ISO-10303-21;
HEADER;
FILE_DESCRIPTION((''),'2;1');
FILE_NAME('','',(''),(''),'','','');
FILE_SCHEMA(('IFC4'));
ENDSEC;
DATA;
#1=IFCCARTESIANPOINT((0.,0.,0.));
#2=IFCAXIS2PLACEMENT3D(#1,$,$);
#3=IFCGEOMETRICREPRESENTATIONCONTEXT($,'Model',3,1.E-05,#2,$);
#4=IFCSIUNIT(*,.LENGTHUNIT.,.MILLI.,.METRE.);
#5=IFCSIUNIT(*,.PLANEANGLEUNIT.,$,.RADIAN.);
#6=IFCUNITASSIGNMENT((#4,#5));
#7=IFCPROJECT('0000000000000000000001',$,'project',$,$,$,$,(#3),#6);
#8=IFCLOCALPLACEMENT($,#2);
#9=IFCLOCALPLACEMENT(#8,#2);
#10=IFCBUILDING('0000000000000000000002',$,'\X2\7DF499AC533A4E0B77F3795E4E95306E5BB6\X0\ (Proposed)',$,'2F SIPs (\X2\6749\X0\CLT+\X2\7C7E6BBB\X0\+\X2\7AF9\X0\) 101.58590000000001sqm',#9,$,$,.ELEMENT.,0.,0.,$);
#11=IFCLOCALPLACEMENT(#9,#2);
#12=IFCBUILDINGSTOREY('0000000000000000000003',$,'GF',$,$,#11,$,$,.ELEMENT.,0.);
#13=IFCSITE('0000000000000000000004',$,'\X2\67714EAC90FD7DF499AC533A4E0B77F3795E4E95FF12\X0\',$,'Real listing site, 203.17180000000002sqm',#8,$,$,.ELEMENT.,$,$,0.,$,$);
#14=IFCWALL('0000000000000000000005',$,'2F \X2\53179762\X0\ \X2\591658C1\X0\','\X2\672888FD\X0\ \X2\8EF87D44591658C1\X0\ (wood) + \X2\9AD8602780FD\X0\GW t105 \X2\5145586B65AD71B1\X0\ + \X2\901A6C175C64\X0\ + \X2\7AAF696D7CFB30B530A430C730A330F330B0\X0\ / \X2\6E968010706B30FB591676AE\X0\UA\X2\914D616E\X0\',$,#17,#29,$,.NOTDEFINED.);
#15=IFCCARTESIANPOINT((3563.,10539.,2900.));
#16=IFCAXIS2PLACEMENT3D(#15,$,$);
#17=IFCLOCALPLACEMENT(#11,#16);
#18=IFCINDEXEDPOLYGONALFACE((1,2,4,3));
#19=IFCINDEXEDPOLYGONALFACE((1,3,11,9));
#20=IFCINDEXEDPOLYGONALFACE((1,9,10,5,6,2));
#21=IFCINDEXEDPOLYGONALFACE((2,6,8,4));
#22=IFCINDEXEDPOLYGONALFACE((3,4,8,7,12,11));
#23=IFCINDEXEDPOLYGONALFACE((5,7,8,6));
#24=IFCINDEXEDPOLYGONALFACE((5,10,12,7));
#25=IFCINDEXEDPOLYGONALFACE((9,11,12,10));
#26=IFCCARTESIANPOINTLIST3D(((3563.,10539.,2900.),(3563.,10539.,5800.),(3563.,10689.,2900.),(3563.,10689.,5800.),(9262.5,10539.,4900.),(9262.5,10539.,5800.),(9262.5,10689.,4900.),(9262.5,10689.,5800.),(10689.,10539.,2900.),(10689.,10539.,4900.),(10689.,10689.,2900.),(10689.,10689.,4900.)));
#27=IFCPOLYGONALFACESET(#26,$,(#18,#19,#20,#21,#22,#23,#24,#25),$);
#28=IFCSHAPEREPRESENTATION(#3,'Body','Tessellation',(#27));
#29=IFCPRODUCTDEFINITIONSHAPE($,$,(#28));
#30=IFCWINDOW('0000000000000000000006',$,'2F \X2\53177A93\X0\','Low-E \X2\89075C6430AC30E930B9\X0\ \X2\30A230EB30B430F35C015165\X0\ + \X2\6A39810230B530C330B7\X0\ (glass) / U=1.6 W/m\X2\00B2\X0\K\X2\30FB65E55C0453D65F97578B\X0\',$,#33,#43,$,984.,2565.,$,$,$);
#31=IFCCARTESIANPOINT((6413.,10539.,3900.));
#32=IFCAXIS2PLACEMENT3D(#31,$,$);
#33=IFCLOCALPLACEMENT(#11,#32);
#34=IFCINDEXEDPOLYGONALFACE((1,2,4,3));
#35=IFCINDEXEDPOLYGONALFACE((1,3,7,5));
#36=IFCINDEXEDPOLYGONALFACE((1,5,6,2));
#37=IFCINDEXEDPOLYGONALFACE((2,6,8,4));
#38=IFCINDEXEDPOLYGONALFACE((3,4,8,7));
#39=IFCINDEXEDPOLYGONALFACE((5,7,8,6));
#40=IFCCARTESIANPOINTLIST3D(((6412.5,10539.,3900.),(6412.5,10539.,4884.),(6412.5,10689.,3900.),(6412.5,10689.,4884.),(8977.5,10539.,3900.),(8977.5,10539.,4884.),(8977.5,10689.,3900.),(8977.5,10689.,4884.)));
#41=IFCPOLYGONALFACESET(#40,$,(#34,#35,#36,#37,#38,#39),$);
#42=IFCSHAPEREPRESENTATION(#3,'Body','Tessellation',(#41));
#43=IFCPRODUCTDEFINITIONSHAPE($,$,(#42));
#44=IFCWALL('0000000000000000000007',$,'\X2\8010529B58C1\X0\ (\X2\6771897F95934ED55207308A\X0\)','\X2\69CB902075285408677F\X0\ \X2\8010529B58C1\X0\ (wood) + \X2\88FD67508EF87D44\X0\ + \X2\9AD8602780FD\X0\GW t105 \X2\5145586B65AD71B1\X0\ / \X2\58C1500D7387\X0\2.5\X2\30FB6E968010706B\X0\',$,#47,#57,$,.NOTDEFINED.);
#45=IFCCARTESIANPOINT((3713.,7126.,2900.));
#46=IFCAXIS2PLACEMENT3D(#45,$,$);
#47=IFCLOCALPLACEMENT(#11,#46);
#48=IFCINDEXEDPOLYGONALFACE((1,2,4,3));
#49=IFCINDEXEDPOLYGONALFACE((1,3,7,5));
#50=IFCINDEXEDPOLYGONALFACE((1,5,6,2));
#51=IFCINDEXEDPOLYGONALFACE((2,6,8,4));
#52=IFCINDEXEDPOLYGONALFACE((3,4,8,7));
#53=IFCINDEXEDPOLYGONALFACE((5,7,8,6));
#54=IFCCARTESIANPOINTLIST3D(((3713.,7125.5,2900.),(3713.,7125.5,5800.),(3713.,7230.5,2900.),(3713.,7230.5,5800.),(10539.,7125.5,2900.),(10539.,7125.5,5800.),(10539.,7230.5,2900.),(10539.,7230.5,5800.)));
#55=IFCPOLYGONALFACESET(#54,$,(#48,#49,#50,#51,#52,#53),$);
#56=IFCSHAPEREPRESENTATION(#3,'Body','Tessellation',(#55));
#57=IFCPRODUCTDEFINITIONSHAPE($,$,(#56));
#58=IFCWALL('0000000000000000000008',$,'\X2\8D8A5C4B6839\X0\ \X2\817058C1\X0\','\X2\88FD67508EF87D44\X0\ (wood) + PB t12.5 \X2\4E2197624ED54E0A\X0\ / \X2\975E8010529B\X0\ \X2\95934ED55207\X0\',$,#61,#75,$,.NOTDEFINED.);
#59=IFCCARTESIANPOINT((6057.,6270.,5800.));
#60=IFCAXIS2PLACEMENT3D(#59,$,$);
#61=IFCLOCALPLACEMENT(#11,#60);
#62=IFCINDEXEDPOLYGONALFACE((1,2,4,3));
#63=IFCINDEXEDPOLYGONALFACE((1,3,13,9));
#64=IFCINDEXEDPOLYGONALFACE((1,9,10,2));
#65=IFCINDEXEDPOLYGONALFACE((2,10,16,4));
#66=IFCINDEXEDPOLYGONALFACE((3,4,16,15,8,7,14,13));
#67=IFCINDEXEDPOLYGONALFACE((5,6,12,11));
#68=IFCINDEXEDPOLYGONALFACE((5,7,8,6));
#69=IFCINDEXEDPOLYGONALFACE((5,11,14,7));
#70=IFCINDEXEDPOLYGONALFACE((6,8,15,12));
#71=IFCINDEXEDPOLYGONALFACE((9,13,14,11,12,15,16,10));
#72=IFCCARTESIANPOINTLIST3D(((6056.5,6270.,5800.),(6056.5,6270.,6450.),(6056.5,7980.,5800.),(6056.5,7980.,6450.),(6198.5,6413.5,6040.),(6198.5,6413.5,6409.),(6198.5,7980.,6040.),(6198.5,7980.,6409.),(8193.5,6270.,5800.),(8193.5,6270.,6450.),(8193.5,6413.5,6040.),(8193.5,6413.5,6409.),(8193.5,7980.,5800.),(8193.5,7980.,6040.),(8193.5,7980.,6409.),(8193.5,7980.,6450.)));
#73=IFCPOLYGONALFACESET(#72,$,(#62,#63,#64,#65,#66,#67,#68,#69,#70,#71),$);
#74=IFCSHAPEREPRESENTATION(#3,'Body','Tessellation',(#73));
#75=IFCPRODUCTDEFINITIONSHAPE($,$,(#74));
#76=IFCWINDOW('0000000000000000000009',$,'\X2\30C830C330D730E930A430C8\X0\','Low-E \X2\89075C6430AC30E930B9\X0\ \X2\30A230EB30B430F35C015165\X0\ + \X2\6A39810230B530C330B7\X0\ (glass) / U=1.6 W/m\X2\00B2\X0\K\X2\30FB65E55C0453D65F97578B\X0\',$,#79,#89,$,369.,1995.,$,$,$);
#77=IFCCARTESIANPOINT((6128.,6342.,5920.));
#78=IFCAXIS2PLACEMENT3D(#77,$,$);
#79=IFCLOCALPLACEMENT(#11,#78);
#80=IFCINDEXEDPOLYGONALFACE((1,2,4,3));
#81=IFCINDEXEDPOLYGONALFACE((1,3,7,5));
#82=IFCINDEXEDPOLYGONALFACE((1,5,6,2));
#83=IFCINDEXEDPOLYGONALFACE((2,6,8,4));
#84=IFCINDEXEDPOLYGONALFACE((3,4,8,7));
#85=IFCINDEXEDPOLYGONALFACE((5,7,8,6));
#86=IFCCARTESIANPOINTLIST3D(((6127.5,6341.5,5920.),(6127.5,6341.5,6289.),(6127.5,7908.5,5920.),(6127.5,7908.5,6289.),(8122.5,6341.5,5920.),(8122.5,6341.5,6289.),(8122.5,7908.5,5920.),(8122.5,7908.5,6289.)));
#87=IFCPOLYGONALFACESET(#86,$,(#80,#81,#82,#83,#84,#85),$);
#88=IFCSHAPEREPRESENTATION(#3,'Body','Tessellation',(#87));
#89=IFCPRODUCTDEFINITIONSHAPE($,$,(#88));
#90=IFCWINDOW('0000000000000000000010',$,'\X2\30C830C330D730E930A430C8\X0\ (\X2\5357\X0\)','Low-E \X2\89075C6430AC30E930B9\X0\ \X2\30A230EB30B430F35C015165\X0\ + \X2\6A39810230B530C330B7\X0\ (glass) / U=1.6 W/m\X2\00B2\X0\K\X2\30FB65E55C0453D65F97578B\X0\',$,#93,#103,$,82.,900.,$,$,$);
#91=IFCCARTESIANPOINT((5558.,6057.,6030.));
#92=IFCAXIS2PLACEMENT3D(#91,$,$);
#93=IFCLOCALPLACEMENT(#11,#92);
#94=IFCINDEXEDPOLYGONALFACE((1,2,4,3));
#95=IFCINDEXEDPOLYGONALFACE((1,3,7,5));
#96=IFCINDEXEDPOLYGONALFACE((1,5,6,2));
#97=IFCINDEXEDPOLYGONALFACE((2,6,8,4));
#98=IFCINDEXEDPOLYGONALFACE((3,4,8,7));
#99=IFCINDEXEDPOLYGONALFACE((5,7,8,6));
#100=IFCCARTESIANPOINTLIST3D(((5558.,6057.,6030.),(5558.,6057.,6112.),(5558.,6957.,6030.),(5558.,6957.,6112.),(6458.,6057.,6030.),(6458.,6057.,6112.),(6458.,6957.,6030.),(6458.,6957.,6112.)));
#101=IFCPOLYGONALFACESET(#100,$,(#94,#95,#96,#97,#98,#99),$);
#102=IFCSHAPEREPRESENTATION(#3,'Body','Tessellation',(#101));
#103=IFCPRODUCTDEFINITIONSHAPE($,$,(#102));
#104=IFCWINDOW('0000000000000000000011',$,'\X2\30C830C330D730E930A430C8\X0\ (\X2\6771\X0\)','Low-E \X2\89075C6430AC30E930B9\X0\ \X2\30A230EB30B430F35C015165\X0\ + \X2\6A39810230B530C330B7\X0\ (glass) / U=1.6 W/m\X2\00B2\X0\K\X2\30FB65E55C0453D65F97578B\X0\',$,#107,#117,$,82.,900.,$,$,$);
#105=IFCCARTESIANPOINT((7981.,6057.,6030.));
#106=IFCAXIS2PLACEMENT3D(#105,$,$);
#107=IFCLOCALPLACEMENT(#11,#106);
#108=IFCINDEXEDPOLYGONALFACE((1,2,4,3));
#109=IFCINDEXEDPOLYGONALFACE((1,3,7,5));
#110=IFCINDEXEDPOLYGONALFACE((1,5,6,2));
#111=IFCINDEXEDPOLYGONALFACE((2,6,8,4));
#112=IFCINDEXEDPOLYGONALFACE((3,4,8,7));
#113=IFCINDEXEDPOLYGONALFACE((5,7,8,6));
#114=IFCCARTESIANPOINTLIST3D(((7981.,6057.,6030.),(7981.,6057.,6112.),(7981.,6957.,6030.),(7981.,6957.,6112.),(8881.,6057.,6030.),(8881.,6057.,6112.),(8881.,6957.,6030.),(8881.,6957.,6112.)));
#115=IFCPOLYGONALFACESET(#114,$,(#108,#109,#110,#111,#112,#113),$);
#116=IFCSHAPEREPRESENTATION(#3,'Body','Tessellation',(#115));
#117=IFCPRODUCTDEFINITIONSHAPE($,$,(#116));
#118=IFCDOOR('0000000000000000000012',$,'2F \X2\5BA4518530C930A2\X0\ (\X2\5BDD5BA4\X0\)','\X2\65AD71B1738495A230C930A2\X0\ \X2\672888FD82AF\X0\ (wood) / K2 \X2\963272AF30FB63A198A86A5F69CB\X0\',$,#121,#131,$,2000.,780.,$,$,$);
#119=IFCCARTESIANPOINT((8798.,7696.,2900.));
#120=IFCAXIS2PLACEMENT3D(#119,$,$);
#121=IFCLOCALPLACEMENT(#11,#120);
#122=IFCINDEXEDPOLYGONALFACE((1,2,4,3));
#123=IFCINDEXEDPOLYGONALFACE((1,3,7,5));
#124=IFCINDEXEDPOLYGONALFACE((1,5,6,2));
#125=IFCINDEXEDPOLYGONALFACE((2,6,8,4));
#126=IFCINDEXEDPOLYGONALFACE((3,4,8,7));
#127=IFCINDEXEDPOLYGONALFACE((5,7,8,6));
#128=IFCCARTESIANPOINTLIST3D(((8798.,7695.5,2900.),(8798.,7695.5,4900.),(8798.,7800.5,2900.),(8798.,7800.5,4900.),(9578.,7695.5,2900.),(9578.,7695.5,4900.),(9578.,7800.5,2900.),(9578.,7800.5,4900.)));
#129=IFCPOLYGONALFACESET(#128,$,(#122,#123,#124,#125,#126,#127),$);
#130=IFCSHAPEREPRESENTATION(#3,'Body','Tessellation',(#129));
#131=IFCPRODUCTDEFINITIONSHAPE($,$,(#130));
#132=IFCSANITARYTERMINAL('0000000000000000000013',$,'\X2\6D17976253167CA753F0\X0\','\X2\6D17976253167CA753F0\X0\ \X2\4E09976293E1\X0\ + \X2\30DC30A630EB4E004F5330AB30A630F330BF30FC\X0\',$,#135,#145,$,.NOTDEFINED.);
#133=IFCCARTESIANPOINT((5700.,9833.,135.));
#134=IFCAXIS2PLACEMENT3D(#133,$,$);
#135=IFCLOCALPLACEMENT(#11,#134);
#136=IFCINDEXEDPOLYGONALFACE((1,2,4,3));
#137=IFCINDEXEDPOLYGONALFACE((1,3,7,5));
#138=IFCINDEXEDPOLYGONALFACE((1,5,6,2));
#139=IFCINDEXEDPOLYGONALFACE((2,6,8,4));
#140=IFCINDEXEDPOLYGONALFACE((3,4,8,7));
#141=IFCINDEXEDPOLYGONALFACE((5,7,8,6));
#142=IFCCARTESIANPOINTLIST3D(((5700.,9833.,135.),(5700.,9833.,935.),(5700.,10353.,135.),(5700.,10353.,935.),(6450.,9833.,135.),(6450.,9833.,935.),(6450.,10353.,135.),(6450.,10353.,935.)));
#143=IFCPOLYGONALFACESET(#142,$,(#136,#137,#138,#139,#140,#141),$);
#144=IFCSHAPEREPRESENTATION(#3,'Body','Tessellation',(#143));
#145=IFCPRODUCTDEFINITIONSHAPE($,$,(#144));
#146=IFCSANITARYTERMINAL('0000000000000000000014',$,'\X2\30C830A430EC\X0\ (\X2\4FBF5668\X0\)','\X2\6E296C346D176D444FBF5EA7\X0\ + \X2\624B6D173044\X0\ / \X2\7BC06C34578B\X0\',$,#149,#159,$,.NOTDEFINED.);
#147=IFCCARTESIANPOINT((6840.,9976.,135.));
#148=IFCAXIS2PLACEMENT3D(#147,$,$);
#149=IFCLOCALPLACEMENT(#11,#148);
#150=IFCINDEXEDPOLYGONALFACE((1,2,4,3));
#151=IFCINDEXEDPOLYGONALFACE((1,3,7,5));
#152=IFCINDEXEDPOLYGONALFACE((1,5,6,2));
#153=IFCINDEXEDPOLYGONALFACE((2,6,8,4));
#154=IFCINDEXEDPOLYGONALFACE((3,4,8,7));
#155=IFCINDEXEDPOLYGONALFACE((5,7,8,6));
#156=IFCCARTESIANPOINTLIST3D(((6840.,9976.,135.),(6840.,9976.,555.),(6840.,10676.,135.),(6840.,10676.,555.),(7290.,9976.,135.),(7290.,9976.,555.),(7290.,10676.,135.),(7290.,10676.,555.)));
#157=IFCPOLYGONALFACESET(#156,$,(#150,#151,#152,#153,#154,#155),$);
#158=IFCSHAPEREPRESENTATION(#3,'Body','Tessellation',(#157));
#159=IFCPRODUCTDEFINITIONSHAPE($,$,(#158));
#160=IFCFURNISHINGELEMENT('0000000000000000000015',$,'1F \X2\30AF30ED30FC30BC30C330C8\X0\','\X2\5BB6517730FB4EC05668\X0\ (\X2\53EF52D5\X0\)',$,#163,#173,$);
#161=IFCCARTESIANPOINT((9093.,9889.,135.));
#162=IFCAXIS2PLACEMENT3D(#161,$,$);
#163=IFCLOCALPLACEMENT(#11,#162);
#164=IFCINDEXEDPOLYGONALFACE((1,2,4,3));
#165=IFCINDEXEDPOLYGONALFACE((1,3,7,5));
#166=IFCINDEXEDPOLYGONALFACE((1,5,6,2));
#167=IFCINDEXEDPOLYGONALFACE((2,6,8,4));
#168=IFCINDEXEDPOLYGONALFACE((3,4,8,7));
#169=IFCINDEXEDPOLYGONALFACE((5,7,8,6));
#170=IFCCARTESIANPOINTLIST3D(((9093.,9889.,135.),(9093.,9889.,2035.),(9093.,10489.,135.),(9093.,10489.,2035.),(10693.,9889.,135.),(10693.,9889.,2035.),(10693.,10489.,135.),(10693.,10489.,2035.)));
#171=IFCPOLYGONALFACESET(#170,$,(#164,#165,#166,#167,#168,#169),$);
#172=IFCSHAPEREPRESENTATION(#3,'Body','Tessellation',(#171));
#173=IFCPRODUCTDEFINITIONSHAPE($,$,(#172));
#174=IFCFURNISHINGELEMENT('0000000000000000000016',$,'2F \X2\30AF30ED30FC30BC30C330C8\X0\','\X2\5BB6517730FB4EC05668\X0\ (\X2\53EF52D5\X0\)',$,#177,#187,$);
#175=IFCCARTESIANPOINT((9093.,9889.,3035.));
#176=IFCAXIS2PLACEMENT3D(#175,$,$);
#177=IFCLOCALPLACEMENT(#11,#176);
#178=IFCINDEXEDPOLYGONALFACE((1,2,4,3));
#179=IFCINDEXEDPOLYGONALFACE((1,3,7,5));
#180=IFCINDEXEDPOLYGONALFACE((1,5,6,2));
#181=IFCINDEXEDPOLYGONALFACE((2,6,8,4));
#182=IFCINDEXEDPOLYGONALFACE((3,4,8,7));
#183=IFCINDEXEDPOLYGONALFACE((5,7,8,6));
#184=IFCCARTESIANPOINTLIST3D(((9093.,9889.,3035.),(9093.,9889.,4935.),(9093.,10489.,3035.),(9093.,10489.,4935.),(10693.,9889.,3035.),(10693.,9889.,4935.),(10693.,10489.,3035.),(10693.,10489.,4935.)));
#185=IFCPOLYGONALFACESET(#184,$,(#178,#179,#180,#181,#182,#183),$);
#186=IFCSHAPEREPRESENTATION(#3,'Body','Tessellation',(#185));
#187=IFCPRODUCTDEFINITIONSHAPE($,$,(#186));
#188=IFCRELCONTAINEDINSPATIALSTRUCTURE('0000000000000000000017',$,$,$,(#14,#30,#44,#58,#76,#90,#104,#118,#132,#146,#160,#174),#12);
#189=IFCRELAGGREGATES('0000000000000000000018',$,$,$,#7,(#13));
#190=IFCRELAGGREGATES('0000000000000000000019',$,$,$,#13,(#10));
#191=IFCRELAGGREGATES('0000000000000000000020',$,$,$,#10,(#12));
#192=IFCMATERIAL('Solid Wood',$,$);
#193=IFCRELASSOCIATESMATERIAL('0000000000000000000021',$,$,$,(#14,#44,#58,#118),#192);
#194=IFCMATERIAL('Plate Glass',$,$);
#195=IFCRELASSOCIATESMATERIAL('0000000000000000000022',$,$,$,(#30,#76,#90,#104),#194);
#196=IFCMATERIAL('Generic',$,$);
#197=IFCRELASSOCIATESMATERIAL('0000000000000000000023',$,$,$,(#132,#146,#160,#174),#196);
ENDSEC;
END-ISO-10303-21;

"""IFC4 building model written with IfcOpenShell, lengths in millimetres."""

from ifc_helpers import new_model, si_unit, frame, frame_2d, origin, place, context, project, spatial, rectangle, extrude, material, element, fill, save


model = new_model("IFC4")

# Units and contexts
model_context = context("Model", 3, precision=1e-05, world=origin())
ifc_project = project(units=[si_unit("LENGTHUNIT", "METRE", prefix="MILLI"), si_unit("PLANEANGLEUNIT", "RADIAN")], contexts=[model_context])

# Site, building, storey
site_placement = place(None, origin())
site = spatial("IfcSite", under=ifc_project, at=site_placement, Name="東京都練馬区下石神井２", ObjectType="Real listing site, 203.17180000000002sqm", CompositionType="ELEMENT", RefElevation=0.0)
building_placement = place(site_placement, origin())
building = spatial("IfcBuilding", under=site, at=building_placement, Name="練馬区下石神井の家 (Proposed)", ObjectType="2F SIPs (杉CLT+籾殻+竹) 101.58590000000001sqm", CompositionType="ELEMENT", ElevationOfRefHeight=0.0, ElevationOfTerrain=0.0)
storey_placement = place(building_placement, origin())
storey = spatial("IfcBuildingStorey", under=building, at=storey_placement, Name="GF", CompositionType="ELEMENT", Elevation=0.0)

# Wall, opening, window
ifc_material_1 = material(Name="Solid Wood")
wall_1_placement = place(storey_placement, frame((3563.0, 10539.0, 2900.0)))
wall_1 = element("IfcWall", 1, at=wall_1_placement, inside=storey, material=ifc_material_1, Name="2F 北面 外壁", Description="木製 軸組外壁 (wood) + 高性能GW t105 充填断熱 + 通気層 + 窯業系サイディング / 準耐火・外皮UA配慮", PredefinedType="NOTDEFINED", context=model_context, shape_type="SweptSolid", body=[
    extrude(rectangle(XDim=7126.0, YDim=150.0, at=frame_2d((3563.0, 75.0))), frame((3563.0, 10539.0, 2900.0)), (0.0, 0.0, 1.0), 2900.0),
])
opening_1_placement = place(storey_placement, frame((6413.0, 10539.0, 3900.0)))
opening_1 = element("IfcOpeningElement", 2, at=opening_1_placement, cuts=wall_1, PredefinedType="NOTDEFINED", context=model_context, shape_type="SweptSolid", body=[
    extrude(rectangle(XDim=2565.0, YDim=150.0, at=frame_2d((1282.0, 75.0))), frame((6413.0, 10539.0, 3900.0)), (0.0, 0.0, 1.0), 984.0),
])
ifc_material_2 = material(Name="Plate Glass")
window_1_placement = place(storey_placement, frame((6413.0, 10539.0, 3900.0)))
window_1 = element("IfcWindow", 3, at=window_1_placement, inside=storey, material=ifc_material_2, Name="2F 北窓", Description="Low-E 複層ガラス アルゴン封入 + 樹脂サッシ (glass) / U=1.6 W/m²K・日射取得型", OverallHeight=984.0, OverallWidth=2565.0, context=model_context, shape_type="SweptSolid", body=[
    extrude(rectangle(XDim=2565.0, YDim=150.0, at=frame_2d((1282.0, 75.0))), frame((6413.0, 10539.0, 3900.0)), (0.0, 0.0, 1.0), 984.0),
])
fill(opening_1, window_1)

# Wall
wall_2_placement = place(storey_placement, frame((3713.0, 7126.0, 2900.0)))
element("IfcWall", 4, at=wall_2_placement, inside=storey, material=ifc_material_1, Name="耐力壁 (東西間仕切り)", Description="構造用合板 耐力壁 (wood) + 製材軸組 + 高性能GW t105 充填断熱 / 壁倍率2.5・準耐火", PredefinedType="NOTDEFINED", context=model_context, shape_type="SweptSolid", body=[
    extrude(rectangle(XDim=6826.0, YDim=105.0, at=frame_2d((3413.0, 52.0))), frame((3713.0, 7126.0, 2900.0)), (0.0, 0.0, 1.0), 2900.0),
])

# Wall, openings, windows
wall_3_placement = place(storey_placement, frame((6057.0, 6270.0, 5800.0)))
wall_3 = element("IfcWall", 5, at=wall_3_placement, inside=storey, material=ifc_material_1, Name="越屋根 腰壁", Description="製材軸組 (wood) + PB t12.5 両面仕上 / 非耐力 間仕切", PredefinedType="NOTDEFINED", context=model_context, shape_type="SweptSolid", body=[
    extrude(rectangle(XDim=2137.0, YDim=1710.0, at=frame_2d((1068.0, 855.0))), frame((6057.0, 6270.0, 5800.0)), (0.0, 0.0, 1.0), 650.0),
])
opening_2_placement = place(storey_placement, frame((6128.0, 6342.0, 5920.0)))
opening_2 = element("IfcOpeningElement", 6, at=opening_2_placement, cuts=wall_3, PredefinedType="NOTDEFINED", context=model_context, shape_type="SweptSolid", body=[
    extrude(rectangle(XDim=1995.0, YDim=1567.0, at=frame_2d((997.0, 783.0))), frame((6128.0, 6342.0, 5920.0)), (0.0, 0.0, 1.0), 369.0),
])
opening_3_placement = place(storey_placement, frame((5558.0, 6057.0, 6030.0)))
opening_3 = element("IfcOpeningElement", 7, at=opening_3_placement, cuts=wall_3, PredefinedType="NOTDEFINED", context=model_context, shape_type="SweptSolid", body=[
    extrude(rectangle(XDim=900.0, YDim=900.0, at=frame_2d((450.0, 450.0))), frame((5558.0, 6057.0, 6030.0)), (0.0, 0.0, 1.0), 82.0),
])
opening_4_placement = place(storey_placement, frame((7981.0, 6057.0, 6030.0)))
opening_4 = element("IfcOpeningElement", 8, at=opening_4_placement, cuts=wall_3, PredefinedType="NOTDEFINED", context=model_context, shape_type="SweptSolid", body=[
    extrude(rectangle(XDim=900.0, YDim=900.0, at=frame_2d((450.0, 450.0))), frame((7981.0, 6057.0, 6030.0)), (0.0, 0.0, 1.0), 82.0),
])
window_2_placement = place(storey_placement, frame((6128.0, 6342.0, 5920.0)))
window_2 = element("IfcWindow", 9, at=window_2_placement, inside=storey, material=ifc_material_2, Name="トップライト", Description="Low-E 複層ガラス アルゴン封入 + 樹脂サッシ (glass) / U=1.6 W/m²K・日射取得型", OverallHeight=369.0, OverallWidth=1995.0, context=model_context, shape_type="SweptSolid", body=[
    extrude(rectangle(XDim=1995.0, YDim=1567.0, at=frame_2d((997.0, 783.0))), frame((6128.0, 6342.0, 5920.0)), (0.0, 0.0, 1.0), 369.0),
])
fill(opening_2, window_2)
window_3_placement = place(storey_placement, frame((5558.0, 6057.0, 6030.0)))
window_3 = element("IfcWindow", 10, at=window_3_placement, inside=storey, material=ifc_material_2, Name="トップライト (南)", Description="Low-E 複層ガラス アルゴン封入 + 樹脂サッシ (glass) / U=1.6 W/m²K・日射取得型", OverallHeight=82.0, OverallWidth=900.0, context=model_context, shape_type="SweptSolid", body=[
    extrude(rectangle(XDim=900.0, YDim=900.0, at=frame_2d((450.0, 450.0))), frame((5558.0, 6057.0, 6030.0)), (0.0, 0.0, 1.0), 82.0),
])
fill(opening_3, window_3)
window_4_placement = place(storey_placement, frame((7981.0, 6057.0, 6030.0)))
window_4 = element("IfcWindow", 11, at=window_4_placement, inside=storey, material=ifc_material_2, Name="トップライト (東)", Description="Low-E 複層ガラス アルゴン封入 + 樹脂サッシ (glass) / U=1.6 W/m²K・日射取得型", OverallHeight=82.0, OverallWidth=900.0, context=model_context, shape_type="SweptSolid", body=[
    extrude(rectangle(XDim=900.0, YDim=900.0, at=frame_2d((450.0, 450.0))), frame((7981.0, 6057.0, 6030.0)), (0.0, 0.0, 1.0), 82.0),
])
fill(opening_4, window_4)

# Door
door_placement = place(storey_placement, frame((8798.0, 7696.0, 2900.0)))
element("IfcDoor", 12, at=door_placement, inside=storey, material=ifc_material_1, Name="2F 室内ドア (寝室)", Description="断熱玄関ドア 木製芯 (wood) / K2 防犯・採風機構", OverallHeight=2000.0, OverallWidth=780.0, context=model_context, shape_type="SweptSolid", body=[
    extrude(rectangle(XDim=780.0, YDim=105.0, at=frame_2d((390.0, 52.0))), frame((8798.0, 7696.0, 2900.0)), (0.0, 0.0, 1.0), 2000.0),
])

# Sanitary terminals
ifc_material_3 = material(Name="Generic")
sanitary_terminal_1_placement = place(storey_placement, frame((5700.0, 9833.0, 135.0)))
element("IfcSanitaryTerminal", 13, at=sanitary_terminal_1_placement, inside=storey, material=ifc_material_3, Name="洗面化粧台", Description="洗面化粧台 三面鏡 + ボウル一体カウンター", PredefinedType="NOTDEFINED", context=model_context, shape_type="SweptSolid", body=[
    extrude(rectangle(XDim=750.0, YDim=520.0, at=frame_2d((375.0, 260.0))), frame((5700.0, 9833.0, 135.0)), (0.0, 0.0, 1.0), 800.0),
])
sanitary_terminal_2_placement = place(storey_placement, frame((6840.0, 9976.0, 135.0)))
element("IfcSanitaryTerminal", 14, at=sanitary_terminal_2_placement, inside=storey, material=ifc_material_3, Name="トイレ (便器)", Description="温水洗浄便座 + 手洗い / 節水型", PredefinedType="NOTDEFINED", context=model_context, shape_type="SweptSolid", body=[
    extrude(rectangle(XDim=450.0, YDim=700.0, at=frame_2d((225.0, 350.0))), frame((6840.0, 9976.0, 135.0)), (0.0, 0.0, 1.0), 420.0),
])

# Furnishing elements
furnishing_1_placement = place(storey_placement, frame((9093.0, 9889.0, 135.0)))
element("IfcFurnishingElement", 15, at=furnishing_1_placement, inside=storey, material=ifc_material_3, Name="1F クローゼット", Description="家具・什器 (可動)", context=model_context, shape_type="SweptSolid", body=[
    extrude(rectangle(XDim=1600.0, YDim=600.0, at=frame_2d((800.0, 300.0))), frame((9093.0, 9889.0, 135.0)), (0.0, 0.0, 1.0), 1900.0),
])
furnishing_2_placement = place(storey_placement, frame((9093.0, 9889.0, 3035.0)))
element("IfcFurnishingElement", 16, at=furnishing_2_placement, inside=storey, material=ifc_material_3, Name="2F クローゼット", Description="家具・什器 (可動)", context=model_context, shape_type="SweptSolid", body=[
    extrude(rectangle(XDim=1600.0, YDim=600.0, at=frame_2d((800.0, 300.0))), frame((9093.0, 9889.0, 3035.0)), (0.0, 0.0, 1.0), 1900.0),
])

save(model, "model.ifc")
